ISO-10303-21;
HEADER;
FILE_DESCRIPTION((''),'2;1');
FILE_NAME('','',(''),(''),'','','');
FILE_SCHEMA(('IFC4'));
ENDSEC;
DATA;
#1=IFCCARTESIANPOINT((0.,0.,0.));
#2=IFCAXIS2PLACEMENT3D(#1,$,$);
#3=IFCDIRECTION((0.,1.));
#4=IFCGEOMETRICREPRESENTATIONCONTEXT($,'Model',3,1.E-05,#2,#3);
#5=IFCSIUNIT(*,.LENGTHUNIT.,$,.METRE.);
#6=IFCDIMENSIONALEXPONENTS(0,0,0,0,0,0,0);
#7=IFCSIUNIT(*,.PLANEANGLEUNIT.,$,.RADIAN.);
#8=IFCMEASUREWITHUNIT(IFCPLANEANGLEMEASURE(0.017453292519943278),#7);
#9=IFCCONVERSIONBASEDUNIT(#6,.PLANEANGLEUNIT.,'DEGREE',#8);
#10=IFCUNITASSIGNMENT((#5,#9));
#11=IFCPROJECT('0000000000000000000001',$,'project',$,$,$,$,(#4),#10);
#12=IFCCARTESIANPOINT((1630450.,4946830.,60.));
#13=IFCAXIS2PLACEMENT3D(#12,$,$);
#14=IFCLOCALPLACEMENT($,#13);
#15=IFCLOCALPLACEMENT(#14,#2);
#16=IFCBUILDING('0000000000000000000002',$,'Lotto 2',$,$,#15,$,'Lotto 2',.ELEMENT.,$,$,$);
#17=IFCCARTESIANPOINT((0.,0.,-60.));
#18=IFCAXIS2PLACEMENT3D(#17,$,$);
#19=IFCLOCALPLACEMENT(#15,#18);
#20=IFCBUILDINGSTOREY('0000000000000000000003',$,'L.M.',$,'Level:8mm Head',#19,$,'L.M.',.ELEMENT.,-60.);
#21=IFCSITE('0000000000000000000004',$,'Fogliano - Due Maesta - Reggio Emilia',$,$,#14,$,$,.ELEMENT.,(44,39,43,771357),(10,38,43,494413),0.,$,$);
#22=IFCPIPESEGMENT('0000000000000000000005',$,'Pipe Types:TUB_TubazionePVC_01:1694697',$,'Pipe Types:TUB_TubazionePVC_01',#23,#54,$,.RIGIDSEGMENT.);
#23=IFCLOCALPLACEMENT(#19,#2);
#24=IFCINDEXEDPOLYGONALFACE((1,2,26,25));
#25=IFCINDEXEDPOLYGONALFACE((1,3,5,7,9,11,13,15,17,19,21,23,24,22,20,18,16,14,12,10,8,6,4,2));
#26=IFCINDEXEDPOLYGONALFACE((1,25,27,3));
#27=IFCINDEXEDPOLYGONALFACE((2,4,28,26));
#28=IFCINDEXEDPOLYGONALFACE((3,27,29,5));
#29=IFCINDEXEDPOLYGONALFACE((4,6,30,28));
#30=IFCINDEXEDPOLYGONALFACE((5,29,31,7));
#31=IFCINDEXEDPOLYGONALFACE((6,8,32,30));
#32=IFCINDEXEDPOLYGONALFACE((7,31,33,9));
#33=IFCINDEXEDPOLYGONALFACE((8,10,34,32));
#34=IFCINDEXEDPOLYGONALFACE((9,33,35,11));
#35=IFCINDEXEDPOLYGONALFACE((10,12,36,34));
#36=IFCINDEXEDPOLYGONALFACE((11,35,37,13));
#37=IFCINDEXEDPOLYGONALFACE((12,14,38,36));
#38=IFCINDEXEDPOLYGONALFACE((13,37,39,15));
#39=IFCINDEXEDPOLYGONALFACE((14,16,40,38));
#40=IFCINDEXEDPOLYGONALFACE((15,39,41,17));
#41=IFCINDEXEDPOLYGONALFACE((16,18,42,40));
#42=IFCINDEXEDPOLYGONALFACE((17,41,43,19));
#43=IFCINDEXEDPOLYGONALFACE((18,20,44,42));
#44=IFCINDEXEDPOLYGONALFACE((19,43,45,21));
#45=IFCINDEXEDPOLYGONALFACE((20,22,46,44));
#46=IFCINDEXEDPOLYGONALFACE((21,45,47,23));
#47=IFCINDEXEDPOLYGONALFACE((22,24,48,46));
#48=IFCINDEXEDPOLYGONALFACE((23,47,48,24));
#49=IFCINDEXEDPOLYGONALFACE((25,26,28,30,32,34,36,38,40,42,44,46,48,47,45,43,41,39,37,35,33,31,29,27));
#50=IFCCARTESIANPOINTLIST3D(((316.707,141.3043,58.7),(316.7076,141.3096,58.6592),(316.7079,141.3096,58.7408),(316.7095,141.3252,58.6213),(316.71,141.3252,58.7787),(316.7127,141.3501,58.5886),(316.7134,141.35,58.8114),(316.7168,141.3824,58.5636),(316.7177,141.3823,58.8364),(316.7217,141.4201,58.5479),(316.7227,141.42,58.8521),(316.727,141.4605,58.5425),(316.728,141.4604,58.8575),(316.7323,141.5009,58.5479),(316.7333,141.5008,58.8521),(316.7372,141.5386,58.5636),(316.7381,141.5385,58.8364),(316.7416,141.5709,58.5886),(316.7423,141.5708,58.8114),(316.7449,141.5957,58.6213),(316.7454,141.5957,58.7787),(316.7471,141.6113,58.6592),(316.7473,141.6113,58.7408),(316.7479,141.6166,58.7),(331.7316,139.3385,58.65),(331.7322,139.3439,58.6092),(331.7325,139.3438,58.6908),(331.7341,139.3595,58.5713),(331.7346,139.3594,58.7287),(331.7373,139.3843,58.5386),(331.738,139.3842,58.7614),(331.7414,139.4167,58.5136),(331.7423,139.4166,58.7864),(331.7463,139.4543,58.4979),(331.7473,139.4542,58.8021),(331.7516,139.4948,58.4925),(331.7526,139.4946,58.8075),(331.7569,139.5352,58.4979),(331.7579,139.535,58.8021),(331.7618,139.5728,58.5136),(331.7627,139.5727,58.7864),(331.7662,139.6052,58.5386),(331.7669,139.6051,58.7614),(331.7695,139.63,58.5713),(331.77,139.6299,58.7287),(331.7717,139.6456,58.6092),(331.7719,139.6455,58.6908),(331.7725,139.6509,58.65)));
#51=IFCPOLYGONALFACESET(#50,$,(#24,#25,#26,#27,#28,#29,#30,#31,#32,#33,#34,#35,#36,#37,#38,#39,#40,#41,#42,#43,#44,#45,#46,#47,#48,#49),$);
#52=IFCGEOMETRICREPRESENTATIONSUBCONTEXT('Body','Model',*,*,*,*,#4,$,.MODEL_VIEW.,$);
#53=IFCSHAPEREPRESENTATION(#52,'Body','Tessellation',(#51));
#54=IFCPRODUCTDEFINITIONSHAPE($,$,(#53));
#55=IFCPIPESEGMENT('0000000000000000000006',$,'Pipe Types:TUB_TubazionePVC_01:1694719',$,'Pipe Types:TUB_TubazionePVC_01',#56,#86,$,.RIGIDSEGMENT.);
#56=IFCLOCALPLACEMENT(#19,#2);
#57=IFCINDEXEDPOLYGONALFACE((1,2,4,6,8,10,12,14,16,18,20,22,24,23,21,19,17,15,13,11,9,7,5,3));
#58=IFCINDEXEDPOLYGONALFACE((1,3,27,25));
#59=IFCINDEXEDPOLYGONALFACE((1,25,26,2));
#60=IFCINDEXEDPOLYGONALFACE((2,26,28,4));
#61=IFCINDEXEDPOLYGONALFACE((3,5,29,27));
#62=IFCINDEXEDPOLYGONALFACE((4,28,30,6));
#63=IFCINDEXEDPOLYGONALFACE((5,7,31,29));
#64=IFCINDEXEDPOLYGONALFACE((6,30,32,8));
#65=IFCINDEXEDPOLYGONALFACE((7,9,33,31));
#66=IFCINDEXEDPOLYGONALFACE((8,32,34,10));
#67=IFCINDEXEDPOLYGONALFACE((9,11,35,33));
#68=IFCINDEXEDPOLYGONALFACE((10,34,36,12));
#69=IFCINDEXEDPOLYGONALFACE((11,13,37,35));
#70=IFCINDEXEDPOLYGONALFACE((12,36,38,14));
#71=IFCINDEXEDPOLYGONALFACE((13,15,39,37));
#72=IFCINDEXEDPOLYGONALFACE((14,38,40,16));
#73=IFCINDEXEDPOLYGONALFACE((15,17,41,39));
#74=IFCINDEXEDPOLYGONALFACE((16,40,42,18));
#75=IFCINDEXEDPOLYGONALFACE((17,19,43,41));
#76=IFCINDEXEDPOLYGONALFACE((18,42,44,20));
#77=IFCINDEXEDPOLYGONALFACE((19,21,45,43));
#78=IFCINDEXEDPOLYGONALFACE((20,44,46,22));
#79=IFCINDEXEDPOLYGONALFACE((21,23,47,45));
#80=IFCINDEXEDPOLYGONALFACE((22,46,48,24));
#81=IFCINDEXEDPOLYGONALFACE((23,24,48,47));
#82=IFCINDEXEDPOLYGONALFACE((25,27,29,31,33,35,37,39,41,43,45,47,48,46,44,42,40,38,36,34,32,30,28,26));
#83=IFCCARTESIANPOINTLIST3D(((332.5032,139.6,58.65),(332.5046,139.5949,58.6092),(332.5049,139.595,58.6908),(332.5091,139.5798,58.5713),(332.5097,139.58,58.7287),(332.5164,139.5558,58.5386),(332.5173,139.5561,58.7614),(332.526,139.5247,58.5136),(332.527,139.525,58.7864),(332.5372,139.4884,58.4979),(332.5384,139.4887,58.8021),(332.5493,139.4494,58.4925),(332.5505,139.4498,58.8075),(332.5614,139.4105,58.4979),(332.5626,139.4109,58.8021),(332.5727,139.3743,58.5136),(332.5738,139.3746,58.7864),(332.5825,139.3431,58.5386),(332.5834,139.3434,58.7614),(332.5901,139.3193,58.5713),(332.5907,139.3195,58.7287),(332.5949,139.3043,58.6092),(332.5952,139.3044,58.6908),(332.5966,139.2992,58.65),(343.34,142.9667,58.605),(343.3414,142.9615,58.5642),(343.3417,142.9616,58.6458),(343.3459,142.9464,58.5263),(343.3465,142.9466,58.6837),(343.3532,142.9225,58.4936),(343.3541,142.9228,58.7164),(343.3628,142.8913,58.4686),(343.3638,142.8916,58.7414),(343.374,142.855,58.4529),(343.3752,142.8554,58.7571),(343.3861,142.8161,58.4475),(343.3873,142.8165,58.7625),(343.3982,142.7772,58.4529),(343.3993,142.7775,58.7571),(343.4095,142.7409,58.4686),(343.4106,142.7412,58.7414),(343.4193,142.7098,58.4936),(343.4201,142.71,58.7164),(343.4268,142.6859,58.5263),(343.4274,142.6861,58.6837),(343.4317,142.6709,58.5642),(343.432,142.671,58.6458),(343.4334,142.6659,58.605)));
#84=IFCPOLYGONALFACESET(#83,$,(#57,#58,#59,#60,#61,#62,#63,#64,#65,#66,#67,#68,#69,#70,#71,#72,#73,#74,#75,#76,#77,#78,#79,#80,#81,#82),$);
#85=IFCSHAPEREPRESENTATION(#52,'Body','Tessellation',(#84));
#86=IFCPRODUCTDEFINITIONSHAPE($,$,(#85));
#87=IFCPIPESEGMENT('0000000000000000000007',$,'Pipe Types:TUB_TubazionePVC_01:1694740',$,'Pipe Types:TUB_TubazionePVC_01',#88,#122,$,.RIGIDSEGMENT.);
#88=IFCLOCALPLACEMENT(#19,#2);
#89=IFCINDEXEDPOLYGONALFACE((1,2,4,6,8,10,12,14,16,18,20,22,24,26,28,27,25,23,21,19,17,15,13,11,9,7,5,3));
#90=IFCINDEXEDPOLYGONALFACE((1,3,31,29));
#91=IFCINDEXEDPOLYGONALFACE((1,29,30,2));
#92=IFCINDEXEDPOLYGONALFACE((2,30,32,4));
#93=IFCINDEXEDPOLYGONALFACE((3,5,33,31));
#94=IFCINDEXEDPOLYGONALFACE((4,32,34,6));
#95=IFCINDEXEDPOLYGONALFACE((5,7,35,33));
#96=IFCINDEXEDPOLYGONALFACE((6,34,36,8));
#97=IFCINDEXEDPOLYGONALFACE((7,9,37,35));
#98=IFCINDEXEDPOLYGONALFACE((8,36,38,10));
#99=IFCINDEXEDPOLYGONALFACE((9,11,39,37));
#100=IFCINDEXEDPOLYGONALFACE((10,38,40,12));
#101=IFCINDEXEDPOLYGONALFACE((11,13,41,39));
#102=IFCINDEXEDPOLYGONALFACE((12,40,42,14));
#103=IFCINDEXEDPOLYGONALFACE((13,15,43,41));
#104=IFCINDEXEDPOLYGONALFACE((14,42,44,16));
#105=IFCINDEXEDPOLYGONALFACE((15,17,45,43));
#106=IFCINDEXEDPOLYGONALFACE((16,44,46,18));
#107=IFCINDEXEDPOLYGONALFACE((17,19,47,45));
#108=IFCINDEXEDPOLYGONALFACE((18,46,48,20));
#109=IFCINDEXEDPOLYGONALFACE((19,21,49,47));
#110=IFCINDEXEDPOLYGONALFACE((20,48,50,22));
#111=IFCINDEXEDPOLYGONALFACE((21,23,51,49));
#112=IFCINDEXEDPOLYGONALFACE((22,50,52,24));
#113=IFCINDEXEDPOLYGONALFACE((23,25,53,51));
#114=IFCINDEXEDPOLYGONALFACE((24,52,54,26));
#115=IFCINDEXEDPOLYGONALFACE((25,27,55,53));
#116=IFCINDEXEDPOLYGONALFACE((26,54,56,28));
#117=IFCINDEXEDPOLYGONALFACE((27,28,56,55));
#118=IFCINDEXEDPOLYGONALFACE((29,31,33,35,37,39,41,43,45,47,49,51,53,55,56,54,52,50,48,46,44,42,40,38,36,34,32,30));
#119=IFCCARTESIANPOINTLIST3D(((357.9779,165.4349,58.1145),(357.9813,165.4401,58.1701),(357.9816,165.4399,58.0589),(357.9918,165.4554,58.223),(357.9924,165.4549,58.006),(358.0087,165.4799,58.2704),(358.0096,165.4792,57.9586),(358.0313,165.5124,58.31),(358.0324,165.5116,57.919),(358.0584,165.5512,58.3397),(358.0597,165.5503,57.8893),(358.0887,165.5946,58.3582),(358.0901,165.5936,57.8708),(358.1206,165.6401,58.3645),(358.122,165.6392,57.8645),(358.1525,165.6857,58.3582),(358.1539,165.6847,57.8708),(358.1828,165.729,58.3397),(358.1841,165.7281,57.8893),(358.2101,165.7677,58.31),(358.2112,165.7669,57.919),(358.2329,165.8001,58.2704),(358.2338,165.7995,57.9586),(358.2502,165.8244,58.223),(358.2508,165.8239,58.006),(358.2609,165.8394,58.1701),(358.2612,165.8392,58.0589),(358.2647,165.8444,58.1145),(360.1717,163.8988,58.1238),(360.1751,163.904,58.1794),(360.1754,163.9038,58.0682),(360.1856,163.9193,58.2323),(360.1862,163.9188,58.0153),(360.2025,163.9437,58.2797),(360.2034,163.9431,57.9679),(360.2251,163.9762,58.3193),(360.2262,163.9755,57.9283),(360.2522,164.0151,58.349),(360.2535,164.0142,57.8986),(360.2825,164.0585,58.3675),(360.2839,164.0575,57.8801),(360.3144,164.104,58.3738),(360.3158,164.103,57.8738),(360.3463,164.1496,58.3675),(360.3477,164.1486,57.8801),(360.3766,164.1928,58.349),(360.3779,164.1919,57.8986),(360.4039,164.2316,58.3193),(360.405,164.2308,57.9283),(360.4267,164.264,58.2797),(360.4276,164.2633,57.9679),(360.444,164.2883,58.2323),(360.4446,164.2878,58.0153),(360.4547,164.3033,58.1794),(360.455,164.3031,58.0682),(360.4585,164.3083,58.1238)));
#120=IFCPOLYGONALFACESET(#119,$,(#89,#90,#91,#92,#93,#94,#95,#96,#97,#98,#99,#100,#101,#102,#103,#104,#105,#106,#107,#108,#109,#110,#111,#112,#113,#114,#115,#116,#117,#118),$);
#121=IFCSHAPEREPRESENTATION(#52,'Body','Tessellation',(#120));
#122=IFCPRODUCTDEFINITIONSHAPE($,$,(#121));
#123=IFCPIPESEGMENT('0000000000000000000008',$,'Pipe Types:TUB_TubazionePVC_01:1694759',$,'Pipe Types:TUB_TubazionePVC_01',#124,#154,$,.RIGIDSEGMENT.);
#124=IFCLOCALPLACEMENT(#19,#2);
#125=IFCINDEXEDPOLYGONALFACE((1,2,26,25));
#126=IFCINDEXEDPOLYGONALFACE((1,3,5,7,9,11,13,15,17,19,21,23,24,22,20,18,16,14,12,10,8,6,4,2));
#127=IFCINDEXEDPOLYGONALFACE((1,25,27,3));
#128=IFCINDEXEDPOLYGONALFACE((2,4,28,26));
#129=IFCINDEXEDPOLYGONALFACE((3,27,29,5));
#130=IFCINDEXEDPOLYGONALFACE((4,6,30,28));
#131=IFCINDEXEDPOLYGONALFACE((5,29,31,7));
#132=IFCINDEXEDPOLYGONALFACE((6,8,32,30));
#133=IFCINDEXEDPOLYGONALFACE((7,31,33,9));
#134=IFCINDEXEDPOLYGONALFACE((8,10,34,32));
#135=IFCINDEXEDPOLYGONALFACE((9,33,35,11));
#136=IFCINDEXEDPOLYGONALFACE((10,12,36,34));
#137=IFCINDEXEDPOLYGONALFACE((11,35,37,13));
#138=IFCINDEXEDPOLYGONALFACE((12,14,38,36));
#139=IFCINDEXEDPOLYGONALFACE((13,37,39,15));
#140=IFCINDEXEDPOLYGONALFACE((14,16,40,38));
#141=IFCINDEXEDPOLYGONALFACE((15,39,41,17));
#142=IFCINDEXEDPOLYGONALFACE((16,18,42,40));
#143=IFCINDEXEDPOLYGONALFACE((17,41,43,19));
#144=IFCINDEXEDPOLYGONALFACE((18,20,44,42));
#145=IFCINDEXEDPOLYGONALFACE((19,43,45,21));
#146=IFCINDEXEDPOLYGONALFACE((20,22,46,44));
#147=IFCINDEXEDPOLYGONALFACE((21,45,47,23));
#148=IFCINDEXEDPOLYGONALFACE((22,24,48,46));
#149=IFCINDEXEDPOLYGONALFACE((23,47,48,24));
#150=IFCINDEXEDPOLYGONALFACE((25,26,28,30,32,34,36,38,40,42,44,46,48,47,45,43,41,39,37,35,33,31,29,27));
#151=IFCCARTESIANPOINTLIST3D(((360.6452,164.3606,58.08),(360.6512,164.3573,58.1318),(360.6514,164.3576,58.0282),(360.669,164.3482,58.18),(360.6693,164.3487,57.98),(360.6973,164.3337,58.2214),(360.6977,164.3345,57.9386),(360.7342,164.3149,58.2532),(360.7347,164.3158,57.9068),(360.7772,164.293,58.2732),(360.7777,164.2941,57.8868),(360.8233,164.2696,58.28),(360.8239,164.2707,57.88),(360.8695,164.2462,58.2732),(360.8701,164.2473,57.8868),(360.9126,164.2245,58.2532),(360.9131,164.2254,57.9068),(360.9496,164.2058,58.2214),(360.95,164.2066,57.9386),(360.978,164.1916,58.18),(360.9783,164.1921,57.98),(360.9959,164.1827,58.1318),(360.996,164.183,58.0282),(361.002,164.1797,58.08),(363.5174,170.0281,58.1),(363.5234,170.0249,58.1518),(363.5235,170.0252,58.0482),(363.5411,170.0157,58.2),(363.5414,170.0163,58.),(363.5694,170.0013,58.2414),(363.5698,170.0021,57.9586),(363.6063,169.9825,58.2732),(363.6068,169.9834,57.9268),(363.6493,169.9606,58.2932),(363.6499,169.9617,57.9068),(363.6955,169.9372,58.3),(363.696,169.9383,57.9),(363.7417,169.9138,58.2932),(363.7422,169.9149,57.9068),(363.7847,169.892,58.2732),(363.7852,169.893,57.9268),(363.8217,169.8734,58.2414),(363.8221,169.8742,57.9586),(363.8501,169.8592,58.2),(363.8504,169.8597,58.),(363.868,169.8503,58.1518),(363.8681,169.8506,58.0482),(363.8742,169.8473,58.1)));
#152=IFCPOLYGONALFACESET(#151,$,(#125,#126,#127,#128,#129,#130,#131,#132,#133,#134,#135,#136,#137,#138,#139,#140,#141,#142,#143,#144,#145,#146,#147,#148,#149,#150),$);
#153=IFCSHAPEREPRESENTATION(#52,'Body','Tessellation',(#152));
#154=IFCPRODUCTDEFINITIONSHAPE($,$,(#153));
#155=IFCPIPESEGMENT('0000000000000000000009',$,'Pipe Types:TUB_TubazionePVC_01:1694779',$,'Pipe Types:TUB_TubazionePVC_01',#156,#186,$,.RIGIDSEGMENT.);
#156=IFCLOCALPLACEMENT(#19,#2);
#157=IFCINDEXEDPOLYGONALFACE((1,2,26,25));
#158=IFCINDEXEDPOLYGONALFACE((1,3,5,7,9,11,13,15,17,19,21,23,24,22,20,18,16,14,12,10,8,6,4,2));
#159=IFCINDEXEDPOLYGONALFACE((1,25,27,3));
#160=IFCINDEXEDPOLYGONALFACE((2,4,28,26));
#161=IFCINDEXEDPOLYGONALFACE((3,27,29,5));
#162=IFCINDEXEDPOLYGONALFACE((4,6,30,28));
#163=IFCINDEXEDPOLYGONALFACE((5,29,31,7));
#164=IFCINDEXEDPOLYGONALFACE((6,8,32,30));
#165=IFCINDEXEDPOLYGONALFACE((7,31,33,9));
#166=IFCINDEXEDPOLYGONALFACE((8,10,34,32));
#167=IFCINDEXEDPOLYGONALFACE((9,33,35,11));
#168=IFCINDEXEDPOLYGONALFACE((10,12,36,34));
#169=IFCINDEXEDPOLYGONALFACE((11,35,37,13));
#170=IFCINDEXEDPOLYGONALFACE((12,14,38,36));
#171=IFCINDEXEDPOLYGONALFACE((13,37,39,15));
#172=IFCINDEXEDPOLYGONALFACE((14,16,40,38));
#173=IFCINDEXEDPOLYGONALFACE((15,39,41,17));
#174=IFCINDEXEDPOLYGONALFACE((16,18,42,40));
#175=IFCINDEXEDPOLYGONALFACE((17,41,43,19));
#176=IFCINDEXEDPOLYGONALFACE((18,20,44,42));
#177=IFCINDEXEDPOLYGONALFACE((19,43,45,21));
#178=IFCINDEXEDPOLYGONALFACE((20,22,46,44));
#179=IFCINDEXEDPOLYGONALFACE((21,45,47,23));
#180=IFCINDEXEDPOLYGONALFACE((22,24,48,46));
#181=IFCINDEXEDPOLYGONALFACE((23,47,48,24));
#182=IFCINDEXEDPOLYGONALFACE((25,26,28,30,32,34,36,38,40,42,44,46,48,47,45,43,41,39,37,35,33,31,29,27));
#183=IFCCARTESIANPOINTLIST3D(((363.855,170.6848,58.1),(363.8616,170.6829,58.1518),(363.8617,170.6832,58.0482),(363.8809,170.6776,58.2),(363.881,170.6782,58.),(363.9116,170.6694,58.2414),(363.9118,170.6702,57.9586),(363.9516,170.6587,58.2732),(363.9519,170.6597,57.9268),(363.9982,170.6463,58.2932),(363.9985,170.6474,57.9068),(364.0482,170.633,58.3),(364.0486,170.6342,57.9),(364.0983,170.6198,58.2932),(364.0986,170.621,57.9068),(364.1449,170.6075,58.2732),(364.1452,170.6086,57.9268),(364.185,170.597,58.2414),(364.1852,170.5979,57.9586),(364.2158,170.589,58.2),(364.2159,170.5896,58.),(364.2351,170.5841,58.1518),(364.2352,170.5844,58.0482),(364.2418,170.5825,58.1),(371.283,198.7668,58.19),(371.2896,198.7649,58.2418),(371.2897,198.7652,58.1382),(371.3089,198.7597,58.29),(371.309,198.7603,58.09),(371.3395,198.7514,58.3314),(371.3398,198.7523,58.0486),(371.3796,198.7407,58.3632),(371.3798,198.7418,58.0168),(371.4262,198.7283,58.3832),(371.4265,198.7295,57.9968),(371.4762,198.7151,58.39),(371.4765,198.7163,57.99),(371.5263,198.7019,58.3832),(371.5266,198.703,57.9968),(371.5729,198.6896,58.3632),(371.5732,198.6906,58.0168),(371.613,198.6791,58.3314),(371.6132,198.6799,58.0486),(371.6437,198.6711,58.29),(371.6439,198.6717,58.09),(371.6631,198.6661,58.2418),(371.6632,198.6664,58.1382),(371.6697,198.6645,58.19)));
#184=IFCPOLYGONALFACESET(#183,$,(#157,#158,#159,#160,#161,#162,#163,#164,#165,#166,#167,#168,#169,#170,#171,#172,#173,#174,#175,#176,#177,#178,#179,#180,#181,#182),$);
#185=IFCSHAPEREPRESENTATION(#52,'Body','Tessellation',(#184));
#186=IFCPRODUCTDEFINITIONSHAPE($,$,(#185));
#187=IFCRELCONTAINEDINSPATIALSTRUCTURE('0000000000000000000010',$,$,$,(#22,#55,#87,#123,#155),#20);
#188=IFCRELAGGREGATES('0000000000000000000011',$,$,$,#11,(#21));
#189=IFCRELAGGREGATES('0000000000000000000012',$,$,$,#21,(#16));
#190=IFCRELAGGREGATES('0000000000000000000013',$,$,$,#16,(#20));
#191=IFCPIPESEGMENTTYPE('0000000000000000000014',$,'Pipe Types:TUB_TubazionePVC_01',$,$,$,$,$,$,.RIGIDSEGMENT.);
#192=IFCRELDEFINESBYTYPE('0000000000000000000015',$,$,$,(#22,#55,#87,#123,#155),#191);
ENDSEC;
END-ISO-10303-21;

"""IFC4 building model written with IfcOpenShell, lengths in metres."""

from ifc_helpers import new_model, entity, si_unit, converted_unit, direction, frame, origin, place, context, subcontext, project, spatial, arc, indexed_curve, outline, extrude, type_object, element, save


model = new_model("IFC4")

# Units and contexts
model_context = context("Model", 3, precision=1e-05, world=origin(), true_north=direction((0.0, 1.0)))
body_context = subcontext(model_context, "Body", "Model", "MODEL_VIEW")
ifc_project = project(units=[si_unit("LENGTHUNIT", "METRE"), converted_unit("PLANEANGLEUNIT", "DEGREE", entity("IfcPlaneAngleMeasure", 0.017453292519943278), si_unit("PLANEANGLEUNIT", "RADIAN"), dimensions=[0, 0, 0, 0, 0, 0, 0])], contexts=[model_context])

# Site, building, storey
site_placement = place(None, frame((1630450.0, 4946830.0, 60.0)))
site = spatial("IfcSite", under=ifc_project, at=site_placement, Name="Fogliano - Due Maesta - Reggio Emilia", CompositionType="ELEMENT", RefLatitude=(44, 39, 43, 771357), RefLongitude=(10, 38, 43, 494413), RefElevation=0.0)
building_placement = place(site_placement, origin())
building = spatial("IfcBuilding", under=site, at=building_placement, Name="Lotto 2", LongName="Lotto 2", CompositionType="ELEMENT")
storey_placement = place(building_placement, frame((0.0, 0.0, -60.0)))
storey = spatial("IfcBuildingStorey", under=building, at=storey_placement, Name="L.M.", ObjectType="Level:8mm Head", LongName="L.M.", CompositionType="ELEMENT", Elevation=-60.0)

# Pipe segments
pipe_segment_type = type_object("IfcPipeSegmentType", Name="Pipe Types:TUB_TubazionePVC_01", PredefinedType="RIGIDSEGMENT")
pipe_segment_1_placement = place(storey_placement, origin())
element("IfcPipeSegment", 1, at=pipe_segment_1_placement, inside=storey, type_object=pipe_segment_type, Name="Pipe Types:TUB_TubazionePVC_01:1694697", ObjectType="Pipe Types:TUB_TubazionePVC_01", PredefinedType="RIGIDSEGMENT", context=body_context, shape_type="SweptSolid", body=[
    extrude(outline(indexed_curve([(0.1575, 0.0), (0.1114, 0.1114), (0.0, 0.1575), (-0.1114, 0.1114), (-0.1575, 0.0), (-0.1114, -0.1114), (0.0, -0.1575), (0.1114, -0.1114)], segments=[arc(1, 2, 3), arc(3, 4, 5), arc(5, 6, 7), arc(7, 8, 1)], self_intersect=False)), frame((331.7521, 139.4947, 58.65), z_axis=(-0.991544, 0.129729, 0.0033), x_axis=(-0.12973, -0.991549, 0.0)), (0.0, 0.0, 1.0), 15.1527),
])
pipe_segment_2_placement = place(storey_placement, origin())
element("IfcPipeSegment", 2, at=pipe_segment_2_placement, inside=storey, type_object=pipe_segment_type, Name="Pipe Types:TUB_TubazionePVC_01:1694719", ObjectType="Pipe Types:TUB_TubazionePVC_01", PredefinedType="RIGIDSEGMENT", context=body_context, shape_type="SweptSolid", body=[
    extrude(outline(indexed_curve([(0.1575, 0.0), (0.1114, 0.1114), (0.0, 0.1575), (-0.1114, 0.1114), (-0.1575, 0.0), (-0.1114, -0.1114), (0.0, -0.1575), (0.1114, -0.1114)], segments=[arc(1, 2, 3), arc(3, 4, 5), arc(5, 6, 7), arc(7, 8, 1)], self_intersect=False)), frame((343.3867, 142.8163, 58.605), z_axis=(-0.954969, -0.296678, 0.003966), x_axis=(0.29668, -0.954977, 0.0)), (0.0, 0.0, 1.0), 11.3478),
])
pipe_segment_3_placement = place(storey_placement, origin())
element("IfcPipeSegment", 3, at=pipe_segment_3_placement, inside=storey, type_object=pipe_segment_type, Name="Pipe Types:TUB_TubazionePVC_01:1694740", ObjectType="Pipe Types:TUB_TubazionePVC_01", PredefinedType="RIGIDSEGMENT", context=body_context, shape_type="SweptSolid", body=[
    extrude(outline(indexed_curve([(0.25, 0.0), (0.1768, 0.1768), (0.0, 0.25), (-0.1768, 0.1768), (-0.25, 0.0), (-0.1768, -0.1768), (0.0, -0.25), (0.1768, -0.1768)], segments=[arc(1, 2, 3), arc(3, 4, 5), arc(5, 6, 7), arc(7, 8, 1)], self_intersect=False)), frame((360.3151, 164.1035, 58.1238), z_axis=(-0.819148, 0.573571, -0.003471), x_axis=(0.573575, 0.819153, 0.0)), (0.0, 0.0, 1.0), 2.6781),
])
pipe_segment_4_placement = place(storey_placement, origin())
element("IfcPipeSegment", 4, at=pipe_segment_4_placement, inside=storey, type_object=pipe_segment_type, Name="Pipe Types:TUB_TubazionePVC_01:1694759", ObjectType="Pipe Types:TUB_TubazionePVC_01", PredefinedType="RIGIDSEGMENT", context=body_context, shape_type="SweptSolid", body=[
    extrude(outline(indexed_curve([(0.2, 0.0), (0.1414, 0.1414), (0.0, 0.2), (-0.1414, 0.1414), (-0.2, 0.0), (-0.1414, -0.1414), (0.0, -0.2), (0.1414, -0.1414)], segments=[arc(1, 2, 3), arc(3, 4, 5), arc(5, 6, 7), arc(7, 8, 1)], self_intersect=False)), frame((360.8236, 164.2702, 58.08), z_axis=(0.452031, 0.891997, 0.003148), x_axis=(0.892001, -0.452033, 0.0)), (0.0, 0.0, 1.0), 6.3538),
])
pipe_segment_5_placement = place(storey_placement, origin())
element("IfcPipeSegment", 5, at=pipe_segment_5_placement, inside=storey, type_object=pipe_segment_type, Name="Pipe Types:TUB_TubazionePVC_01:1694779", ObjectType="Pipe Types:TUB_TubazionePVC_01", PredefinedType="RIGIDSEGMENT", context=body_context, shape_type="SweptSolid", body=[
    extrude(outline(indexed_curve([(0.2, 0.0), (0.1414, 0.1414), (0.0, 0.2), (-0.1414, 0.1414), (-0.2, 0.0), (-0.1414, -0.1414), (0.0, -0.2), (0.1414, -0.1414)], segments=[arc(1, 2, 3), arc(3, 4, 5), arc(5, 6, 7), arc(7, 8, 1)], self_intersect=False)), frame((364.0484, 170.6336, 58.1), z_axis=(0.255714, 0.966747, 0.003098), x_axis=(0.966752, -0.255715, 0.0)), (0.0, 0.0, 1.0), 29.048),
])

save(model, "model.ifc")
